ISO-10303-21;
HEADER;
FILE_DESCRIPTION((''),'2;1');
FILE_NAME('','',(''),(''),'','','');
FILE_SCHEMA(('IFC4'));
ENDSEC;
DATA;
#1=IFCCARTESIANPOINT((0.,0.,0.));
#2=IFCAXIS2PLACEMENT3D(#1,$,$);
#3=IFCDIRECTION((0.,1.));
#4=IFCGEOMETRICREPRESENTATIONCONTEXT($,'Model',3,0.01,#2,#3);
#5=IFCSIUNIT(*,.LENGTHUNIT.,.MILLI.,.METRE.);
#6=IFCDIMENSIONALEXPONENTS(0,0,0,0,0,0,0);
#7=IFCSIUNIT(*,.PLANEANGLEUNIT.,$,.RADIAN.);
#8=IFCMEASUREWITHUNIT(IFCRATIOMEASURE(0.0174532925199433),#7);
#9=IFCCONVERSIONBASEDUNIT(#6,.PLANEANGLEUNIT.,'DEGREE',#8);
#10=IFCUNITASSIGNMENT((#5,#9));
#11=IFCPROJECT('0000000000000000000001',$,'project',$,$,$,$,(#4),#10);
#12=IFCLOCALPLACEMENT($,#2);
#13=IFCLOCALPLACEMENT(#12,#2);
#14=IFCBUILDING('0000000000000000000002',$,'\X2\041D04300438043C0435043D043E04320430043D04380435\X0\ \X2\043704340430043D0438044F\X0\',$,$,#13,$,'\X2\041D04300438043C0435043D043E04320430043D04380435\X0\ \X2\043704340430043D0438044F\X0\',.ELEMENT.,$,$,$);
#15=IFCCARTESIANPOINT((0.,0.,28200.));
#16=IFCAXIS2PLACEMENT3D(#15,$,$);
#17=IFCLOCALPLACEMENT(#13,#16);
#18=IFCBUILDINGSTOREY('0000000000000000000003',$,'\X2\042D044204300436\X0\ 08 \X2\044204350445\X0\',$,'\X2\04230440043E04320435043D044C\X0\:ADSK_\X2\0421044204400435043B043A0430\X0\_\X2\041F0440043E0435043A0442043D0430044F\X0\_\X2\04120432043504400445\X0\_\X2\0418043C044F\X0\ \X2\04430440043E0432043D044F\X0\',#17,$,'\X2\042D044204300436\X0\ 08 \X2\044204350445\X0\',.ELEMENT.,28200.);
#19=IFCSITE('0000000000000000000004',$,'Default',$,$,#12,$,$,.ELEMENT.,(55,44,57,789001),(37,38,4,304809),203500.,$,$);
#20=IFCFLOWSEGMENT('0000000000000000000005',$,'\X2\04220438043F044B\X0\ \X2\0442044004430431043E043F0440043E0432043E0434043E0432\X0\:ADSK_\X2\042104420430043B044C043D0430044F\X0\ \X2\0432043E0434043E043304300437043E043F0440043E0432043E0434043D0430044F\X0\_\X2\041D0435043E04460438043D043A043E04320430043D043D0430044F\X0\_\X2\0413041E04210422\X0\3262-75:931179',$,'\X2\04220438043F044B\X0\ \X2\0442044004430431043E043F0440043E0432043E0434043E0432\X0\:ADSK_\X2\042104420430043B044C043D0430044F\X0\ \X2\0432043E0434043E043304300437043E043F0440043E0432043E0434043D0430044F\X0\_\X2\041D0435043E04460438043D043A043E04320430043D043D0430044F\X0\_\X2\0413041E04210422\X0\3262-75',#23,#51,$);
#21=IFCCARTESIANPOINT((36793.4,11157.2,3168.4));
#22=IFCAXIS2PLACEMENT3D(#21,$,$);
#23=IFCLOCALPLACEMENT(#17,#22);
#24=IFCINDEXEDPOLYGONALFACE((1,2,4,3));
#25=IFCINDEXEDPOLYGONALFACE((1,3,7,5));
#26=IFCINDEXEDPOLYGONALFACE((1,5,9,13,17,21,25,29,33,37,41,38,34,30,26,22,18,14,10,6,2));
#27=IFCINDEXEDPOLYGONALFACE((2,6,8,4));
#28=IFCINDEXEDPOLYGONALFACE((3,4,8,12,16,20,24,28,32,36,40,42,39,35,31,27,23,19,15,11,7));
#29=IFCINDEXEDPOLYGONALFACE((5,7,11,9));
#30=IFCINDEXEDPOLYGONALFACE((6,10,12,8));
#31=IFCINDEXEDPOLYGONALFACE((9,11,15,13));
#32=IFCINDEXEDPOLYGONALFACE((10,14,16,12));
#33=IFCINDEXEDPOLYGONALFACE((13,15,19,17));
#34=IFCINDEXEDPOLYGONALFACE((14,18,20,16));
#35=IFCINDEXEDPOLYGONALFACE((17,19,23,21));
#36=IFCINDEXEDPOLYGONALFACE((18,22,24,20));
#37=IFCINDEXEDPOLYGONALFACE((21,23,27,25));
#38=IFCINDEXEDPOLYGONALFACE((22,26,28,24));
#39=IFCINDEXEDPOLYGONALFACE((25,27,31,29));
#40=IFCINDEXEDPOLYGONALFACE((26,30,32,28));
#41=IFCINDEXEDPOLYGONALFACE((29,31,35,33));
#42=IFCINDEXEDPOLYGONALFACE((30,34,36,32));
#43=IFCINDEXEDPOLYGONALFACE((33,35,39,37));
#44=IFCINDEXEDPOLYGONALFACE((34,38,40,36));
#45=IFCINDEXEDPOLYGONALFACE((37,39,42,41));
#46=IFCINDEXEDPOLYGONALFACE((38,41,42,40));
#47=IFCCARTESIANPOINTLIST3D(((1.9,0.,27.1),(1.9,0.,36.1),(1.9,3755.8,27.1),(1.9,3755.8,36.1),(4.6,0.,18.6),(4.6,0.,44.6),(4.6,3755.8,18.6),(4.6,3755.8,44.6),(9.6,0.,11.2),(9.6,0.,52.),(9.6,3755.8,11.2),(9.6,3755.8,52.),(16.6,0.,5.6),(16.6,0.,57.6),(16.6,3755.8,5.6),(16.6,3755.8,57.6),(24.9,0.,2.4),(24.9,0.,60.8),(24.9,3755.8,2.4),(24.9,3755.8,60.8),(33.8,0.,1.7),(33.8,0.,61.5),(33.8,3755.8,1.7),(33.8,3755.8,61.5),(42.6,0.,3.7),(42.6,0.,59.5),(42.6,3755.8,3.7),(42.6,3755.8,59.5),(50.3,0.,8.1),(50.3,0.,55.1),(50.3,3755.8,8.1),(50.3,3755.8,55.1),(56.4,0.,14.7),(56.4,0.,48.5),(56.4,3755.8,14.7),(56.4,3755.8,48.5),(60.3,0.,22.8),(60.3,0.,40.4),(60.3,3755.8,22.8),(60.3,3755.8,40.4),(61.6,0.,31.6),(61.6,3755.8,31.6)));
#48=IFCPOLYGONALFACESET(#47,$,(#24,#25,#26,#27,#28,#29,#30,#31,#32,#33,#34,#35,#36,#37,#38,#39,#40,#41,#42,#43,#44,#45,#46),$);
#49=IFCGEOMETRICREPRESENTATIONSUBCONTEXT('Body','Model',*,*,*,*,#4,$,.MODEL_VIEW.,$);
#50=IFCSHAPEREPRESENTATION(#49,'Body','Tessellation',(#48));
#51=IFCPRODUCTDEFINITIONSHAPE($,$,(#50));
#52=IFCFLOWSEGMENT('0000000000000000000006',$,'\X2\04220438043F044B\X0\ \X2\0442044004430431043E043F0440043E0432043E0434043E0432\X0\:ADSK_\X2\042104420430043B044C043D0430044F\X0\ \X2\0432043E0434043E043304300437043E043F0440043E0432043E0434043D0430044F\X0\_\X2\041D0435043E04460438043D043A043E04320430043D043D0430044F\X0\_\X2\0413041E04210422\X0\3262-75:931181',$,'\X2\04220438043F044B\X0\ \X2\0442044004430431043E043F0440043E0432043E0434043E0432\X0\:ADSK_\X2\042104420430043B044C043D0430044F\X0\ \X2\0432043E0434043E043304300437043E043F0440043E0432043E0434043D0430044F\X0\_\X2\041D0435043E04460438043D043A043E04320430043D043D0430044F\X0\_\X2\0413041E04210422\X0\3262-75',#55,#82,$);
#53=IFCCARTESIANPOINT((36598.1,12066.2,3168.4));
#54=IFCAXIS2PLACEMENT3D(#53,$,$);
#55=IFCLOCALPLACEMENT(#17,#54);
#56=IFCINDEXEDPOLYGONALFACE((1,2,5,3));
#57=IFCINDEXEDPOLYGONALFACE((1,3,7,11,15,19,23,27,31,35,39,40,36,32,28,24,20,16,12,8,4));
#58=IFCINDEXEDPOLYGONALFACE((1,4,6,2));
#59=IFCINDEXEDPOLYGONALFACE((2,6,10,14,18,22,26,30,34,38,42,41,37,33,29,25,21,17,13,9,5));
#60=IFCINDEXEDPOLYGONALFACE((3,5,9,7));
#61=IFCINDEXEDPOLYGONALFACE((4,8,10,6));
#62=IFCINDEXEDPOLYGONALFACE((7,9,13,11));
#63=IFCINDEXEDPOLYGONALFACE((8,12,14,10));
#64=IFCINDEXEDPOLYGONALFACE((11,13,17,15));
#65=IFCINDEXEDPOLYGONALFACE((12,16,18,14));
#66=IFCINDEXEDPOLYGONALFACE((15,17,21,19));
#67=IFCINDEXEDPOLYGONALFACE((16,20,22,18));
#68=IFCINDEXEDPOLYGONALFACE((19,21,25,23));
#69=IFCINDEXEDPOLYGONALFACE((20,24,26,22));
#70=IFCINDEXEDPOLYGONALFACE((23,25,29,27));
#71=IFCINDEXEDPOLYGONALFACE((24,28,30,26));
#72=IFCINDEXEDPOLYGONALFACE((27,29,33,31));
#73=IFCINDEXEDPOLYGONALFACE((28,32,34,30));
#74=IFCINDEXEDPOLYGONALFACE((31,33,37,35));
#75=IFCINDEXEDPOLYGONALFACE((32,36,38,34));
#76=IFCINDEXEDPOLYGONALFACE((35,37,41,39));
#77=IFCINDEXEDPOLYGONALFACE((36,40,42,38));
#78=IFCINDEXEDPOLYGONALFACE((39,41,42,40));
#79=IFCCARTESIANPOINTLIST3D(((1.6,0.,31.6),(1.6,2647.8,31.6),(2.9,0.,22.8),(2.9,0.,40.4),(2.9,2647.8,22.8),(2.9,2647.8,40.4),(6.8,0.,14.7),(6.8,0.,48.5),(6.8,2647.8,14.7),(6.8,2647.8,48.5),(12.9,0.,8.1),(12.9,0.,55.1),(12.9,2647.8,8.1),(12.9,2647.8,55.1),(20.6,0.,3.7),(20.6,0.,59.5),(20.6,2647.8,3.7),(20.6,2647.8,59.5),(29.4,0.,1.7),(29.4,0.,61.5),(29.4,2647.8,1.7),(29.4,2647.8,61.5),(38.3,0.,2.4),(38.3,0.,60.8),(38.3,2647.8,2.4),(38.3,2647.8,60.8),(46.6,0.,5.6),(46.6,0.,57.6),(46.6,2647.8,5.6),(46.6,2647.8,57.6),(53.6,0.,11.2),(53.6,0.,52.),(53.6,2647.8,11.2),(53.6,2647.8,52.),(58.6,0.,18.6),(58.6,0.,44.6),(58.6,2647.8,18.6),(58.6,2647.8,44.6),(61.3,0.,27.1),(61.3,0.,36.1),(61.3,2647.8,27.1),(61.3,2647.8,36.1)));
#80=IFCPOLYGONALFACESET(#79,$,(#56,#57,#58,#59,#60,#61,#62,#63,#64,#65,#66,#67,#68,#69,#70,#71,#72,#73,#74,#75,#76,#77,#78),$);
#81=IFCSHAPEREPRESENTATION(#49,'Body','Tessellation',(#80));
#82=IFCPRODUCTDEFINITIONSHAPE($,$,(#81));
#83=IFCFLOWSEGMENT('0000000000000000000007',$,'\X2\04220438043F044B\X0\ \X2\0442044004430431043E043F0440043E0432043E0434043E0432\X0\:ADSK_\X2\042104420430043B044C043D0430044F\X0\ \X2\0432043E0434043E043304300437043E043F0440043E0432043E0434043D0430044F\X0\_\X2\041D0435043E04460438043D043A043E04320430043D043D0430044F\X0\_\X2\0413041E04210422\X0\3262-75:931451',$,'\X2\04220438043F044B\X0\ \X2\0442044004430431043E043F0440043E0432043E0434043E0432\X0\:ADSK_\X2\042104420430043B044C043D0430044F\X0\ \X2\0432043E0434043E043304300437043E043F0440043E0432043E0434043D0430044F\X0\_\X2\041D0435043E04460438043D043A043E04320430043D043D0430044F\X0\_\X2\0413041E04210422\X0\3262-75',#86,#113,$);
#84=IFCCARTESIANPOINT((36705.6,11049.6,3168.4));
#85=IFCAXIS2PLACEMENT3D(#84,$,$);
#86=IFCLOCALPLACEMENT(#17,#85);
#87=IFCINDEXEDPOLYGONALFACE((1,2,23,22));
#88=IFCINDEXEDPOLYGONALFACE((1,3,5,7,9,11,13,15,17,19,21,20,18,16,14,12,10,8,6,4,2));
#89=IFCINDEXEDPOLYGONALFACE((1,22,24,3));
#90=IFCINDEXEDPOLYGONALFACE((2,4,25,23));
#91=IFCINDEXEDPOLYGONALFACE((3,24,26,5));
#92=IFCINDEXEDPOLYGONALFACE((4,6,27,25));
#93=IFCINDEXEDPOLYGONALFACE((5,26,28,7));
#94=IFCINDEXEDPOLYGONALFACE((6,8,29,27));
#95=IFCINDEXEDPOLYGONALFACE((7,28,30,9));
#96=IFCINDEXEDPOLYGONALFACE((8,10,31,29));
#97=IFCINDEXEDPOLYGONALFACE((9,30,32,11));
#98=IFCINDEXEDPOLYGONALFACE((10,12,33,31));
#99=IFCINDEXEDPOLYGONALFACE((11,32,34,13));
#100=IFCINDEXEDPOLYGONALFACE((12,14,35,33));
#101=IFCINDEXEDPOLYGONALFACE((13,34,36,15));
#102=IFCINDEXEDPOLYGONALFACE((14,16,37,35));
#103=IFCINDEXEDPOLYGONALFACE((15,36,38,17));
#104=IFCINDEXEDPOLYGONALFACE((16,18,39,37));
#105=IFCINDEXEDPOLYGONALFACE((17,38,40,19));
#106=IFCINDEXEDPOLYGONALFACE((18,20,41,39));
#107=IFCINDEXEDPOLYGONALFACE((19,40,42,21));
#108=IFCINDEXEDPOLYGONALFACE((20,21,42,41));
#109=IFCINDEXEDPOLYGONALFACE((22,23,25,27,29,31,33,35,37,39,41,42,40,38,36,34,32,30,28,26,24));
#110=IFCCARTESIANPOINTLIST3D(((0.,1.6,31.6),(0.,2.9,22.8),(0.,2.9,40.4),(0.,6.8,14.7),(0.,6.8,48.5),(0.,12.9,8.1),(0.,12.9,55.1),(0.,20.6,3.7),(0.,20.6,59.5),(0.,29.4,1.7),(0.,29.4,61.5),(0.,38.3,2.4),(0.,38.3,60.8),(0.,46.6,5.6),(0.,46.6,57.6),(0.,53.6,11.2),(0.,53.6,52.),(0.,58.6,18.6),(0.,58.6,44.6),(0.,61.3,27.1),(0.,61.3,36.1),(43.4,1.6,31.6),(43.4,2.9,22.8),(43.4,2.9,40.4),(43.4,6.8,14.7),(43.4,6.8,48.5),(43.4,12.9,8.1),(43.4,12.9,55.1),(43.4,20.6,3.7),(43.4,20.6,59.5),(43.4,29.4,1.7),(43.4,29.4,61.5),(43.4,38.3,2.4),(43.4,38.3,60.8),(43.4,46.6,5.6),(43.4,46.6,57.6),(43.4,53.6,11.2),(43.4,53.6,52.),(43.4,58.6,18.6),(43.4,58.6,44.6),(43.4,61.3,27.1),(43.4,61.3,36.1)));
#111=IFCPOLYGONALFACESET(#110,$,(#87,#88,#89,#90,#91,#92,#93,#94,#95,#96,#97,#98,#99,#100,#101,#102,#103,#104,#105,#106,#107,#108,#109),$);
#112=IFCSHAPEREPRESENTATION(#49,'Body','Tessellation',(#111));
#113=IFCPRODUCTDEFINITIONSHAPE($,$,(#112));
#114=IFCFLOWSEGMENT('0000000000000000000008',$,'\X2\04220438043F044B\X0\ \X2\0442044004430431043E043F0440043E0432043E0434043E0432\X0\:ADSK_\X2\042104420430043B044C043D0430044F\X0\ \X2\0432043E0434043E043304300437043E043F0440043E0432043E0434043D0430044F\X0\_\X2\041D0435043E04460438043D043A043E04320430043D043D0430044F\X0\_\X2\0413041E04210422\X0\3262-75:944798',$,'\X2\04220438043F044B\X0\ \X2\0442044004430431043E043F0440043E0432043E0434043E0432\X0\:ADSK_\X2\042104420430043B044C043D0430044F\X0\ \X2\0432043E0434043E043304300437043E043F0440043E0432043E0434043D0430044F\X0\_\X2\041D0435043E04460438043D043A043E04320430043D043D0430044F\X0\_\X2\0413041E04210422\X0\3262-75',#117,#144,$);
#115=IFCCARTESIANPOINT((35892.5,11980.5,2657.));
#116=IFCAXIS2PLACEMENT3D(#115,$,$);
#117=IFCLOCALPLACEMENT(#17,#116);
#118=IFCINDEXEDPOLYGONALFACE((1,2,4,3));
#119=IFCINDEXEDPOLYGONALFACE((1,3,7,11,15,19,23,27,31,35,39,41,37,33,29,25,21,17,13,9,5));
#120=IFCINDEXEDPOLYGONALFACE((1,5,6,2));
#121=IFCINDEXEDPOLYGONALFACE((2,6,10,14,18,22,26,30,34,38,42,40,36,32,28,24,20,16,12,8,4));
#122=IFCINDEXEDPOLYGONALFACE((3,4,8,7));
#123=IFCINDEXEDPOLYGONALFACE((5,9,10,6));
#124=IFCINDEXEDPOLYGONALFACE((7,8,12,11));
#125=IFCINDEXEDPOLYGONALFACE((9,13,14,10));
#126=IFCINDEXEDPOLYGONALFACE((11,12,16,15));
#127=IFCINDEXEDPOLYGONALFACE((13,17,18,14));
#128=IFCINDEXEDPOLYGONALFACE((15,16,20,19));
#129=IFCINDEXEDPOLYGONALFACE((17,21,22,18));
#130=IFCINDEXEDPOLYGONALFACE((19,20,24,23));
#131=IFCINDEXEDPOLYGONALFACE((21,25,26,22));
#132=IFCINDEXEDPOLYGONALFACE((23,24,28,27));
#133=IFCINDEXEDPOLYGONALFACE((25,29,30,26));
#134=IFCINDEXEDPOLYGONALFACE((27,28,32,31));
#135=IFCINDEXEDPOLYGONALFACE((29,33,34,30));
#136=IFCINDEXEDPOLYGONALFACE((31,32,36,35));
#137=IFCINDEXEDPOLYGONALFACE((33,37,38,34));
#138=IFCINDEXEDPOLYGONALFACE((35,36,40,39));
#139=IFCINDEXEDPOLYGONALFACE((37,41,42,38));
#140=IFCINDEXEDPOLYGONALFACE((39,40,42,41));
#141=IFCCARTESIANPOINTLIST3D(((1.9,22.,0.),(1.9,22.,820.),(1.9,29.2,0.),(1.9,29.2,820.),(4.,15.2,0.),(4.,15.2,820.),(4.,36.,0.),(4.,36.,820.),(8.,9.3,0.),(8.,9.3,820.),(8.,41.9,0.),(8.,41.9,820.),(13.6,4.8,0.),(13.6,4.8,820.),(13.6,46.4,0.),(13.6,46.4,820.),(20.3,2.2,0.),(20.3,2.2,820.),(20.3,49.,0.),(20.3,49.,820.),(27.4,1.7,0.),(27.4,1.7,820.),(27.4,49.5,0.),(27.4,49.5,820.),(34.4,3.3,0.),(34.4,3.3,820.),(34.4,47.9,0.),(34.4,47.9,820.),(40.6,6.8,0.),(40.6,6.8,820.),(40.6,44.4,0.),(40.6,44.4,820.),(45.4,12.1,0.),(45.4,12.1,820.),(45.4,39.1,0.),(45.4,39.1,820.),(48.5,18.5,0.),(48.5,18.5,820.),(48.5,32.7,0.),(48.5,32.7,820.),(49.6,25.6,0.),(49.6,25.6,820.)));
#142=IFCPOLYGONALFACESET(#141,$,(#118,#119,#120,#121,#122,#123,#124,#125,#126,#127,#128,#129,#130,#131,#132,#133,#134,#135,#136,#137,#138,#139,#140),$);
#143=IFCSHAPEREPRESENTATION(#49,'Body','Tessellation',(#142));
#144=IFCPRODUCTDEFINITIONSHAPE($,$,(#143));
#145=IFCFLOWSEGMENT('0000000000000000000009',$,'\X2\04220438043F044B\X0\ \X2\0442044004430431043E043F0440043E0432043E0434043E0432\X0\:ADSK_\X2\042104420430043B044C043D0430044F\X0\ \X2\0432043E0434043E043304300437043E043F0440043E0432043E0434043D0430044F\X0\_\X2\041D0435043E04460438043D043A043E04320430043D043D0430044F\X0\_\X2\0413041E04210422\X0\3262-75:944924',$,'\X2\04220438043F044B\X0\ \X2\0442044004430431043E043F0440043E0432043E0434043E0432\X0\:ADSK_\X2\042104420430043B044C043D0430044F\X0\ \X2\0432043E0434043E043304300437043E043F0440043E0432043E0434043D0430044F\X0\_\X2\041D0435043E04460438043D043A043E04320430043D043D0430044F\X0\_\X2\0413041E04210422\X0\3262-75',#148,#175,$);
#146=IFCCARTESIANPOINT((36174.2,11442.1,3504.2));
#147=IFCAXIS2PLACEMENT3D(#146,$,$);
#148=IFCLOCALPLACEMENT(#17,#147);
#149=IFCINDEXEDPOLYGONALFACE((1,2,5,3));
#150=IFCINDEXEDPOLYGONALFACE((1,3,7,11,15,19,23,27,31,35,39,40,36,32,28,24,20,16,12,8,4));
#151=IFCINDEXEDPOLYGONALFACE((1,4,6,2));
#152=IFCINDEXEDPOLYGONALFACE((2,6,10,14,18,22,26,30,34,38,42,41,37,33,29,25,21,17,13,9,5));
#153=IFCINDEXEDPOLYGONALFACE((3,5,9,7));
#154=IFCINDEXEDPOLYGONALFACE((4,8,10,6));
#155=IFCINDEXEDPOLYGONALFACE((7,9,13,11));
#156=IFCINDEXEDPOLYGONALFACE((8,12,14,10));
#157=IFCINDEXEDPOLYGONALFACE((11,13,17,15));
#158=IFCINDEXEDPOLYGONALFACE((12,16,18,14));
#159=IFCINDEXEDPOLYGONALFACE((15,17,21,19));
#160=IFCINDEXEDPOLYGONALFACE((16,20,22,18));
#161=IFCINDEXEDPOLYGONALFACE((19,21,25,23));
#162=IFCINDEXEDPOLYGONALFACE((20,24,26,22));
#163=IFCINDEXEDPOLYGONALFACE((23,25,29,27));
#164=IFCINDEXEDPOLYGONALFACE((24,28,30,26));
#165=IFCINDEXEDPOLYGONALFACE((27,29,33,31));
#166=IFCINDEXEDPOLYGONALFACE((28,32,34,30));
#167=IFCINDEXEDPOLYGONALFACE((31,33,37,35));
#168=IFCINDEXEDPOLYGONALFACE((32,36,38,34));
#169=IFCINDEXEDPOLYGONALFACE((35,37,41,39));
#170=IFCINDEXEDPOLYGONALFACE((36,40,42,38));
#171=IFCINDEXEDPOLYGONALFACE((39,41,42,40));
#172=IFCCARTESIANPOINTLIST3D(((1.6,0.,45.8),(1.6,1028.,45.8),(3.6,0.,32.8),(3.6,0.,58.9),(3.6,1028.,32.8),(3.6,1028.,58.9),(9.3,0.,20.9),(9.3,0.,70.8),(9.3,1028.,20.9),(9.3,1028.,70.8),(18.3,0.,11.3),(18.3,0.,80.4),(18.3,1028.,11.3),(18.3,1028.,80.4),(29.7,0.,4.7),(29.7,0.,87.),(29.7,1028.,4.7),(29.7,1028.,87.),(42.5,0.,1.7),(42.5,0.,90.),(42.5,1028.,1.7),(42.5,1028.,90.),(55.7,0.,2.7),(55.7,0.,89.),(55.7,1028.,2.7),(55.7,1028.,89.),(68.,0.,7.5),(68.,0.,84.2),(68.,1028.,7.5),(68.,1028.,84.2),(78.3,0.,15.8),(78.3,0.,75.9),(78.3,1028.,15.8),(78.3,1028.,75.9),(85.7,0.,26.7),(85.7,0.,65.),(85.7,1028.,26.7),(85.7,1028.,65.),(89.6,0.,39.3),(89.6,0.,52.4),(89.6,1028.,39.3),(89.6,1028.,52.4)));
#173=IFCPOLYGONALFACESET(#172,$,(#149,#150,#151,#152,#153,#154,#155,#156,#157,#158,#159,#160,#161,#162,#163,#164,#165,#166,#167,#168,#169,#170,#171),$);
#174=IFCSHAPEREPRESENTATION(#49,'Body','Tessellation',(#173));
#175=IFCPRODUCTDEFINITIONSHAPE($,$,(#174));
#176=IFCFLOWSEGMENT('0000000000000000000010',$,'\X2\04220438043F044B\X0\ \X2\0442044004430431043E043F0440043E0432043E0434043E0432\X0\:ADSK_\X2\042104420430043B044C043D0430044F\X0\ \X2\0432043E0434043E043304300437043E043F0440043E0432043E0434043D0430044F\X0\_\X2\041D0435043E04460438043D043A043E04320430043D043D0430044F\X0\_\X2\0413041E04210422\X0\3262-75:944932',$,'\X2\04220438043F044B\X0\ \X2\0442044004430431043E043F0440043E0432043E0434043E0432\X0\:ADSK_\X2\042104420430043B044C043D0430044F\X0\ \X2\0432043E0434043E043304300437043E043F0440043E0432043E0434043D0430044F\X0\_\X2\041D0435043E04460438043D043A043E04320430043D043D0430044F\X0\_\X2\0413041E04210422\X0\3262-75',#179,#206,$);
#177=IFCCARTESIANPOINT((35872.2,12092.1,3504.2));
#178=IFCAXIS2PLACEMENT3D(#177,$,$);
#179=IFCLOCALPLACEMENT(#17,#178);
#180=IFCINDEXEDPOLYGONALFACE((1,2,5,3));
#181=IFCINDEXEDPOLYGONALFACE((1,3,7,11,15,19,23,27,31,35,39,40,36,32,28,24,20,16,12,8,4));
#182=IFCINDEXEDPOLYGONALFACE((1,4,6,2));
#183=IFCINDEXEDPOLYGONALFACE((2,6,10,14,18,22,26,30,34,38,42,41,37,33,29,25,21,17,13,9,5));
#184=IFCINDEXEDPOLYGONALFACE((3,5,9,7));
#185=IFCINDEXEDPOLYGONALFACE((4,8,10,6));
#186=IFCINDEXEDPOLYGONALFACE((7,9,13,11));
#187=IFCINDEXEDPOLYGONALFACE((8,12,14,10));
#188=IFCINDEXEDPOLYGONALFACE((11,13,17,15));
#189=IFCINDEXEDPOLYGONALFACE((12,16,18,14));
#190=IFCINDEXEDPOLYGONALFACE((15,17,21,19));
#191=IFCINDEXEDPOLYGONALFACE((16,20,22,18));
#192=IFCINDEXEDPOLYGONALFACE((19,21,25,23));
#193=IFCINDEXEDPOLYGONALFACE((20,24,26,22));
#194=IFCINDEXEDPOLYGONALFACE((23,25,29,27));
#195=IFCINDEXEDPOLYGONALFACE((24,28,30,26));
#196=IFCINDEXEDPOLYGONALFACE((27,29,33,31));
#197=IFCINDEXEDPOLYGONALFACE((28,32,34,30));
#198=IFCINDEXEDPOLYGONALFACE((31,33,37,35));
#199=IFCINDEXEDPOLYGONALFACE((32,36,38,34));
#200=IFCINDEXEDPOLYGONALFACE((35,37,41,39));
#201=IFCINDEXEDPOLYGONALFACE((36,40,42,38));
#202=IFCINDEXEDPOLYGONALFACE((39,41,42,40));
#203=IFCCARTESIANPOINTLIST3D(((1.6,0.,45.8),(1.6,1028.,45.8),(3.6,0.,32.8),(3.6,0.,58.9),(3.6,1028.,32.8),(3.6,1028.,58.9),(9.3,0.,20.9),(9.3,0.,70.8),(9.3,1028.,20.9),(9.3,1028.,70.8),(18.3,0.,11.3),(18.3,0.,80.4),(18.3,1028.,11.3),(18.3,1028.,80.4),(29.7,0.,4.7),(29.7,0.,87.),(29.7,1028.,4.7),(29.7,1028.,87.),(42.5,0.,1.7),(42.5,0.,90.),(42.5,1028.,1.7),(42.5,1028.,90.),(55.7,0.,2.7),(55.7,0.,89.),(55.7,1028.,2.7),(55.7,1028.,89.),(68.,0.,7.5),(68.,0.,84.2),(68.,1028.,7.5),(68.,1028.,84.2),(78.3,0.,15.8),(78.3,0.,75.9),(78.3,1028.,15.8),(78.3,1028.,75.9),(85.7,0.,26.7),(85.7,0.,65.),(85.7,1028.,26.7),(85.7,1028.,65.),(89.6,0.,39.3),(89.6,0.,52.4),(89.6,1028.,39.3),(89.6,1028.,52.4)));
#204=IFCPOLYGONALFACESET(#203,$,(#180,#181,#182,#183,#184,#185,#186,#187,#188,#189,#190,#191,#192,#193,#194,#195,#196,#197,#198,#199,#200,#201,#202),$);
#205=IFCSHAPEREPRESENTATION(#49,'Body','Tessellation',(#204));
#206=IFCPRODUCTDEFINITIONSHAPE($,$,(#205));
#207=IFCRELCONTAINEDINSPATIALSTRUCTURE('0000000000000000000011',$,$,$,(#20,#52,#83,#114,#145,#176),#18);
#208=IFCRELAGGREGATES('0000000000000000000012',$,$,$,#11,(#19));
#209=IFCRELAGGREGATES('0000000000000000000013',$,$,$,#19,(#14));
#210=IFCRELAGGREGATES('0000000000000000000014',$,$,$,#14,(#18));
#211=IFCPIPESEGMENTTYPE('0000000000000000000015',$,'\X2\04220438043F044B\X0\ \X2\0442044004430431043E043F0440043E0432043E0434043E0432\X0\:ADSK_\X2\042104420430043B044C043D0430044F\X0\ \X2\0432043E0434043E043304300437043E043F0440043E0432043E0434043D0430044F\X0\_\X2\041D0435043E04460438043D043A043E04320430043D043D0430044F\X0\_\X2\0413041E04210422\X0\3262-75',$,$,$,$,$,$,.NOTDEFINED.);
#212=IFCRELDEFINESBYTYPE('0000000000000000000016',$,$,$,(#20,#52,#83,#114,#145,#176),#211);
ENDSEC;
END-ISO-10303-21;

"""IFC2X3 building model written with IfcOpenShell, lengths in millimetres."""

from ifc_helpers import new_model, entity, si_unit, converted_unit, direction, frame, origin, origin_2d_with_axis, place, context, subcontext, project, spatial, circle, extrude, type_object, element, save


model = new_model("IFC2X3")

# Units and contexts
model_context = context("Model", 3, precision=0.01, world=origin(), true_north=direction((0.0, 1.0)))
body_context = subcontext(model_context, "Body", "Model", "MODEL_VIEW")
ifc_project = project(units=[si_unit("LENGTHUNIT", "METRE", prefix="MILLI"), converted_unit("PLANEANGLEUNIT", "DEGREE", entity("IfcRatioMeasure", 0.0174532925199433), si_unit("PLANEANGLEUNIT", "RADIAN"), dimensions=[0, 0, 0, 0, 0, 0, 0])], contexts=[model_context])

# Site, building, storey
site_placement = place(None, origin())
site = spatial("IfcSite", under=ifc_project, at=site_placement, Name="Default", CompositionType="ELEMENT", RefLatitude=(55, 44, 57, 789001), RefLongitude=(37, 38, 4, 304809), RefElevation=203500.0)
building_placement = place(site_placement, origin())
building = spatial("IfcBuilding", under=site, at=building_placement, Name="Наименование здания", LongName="Наименование здания", CompositionType="ELEMENT")
storey_placement = place(building_placement, frame((0.0, 0.0, 28200.0)))
storey = spatial("IfcBuildingStorey", under=building, at=storey_placement, Name="Этаж 08 тех", ObjectType="Уровень:ADSK_Стрелка_Проектная_Вверх_Имя уровня", LongName="Этаж 08 тех", CompositionType="ELEMENT", Elevation=28200.0)

# Flow segments
pipe_segment_type = type_object("IfcPipeSegmentType", Name="Типы трубопроводов:ADSK_Стальная водогазопроводная_Неоцинкованная_ГОСТ3262-75", PredefinedType="NOTDEFINED")
flow_segment_1_placement = place(storey_placement, frame((36793.4, 11157.2, 3168.4)))
element("IfcFlowSegment", 1, at=flow_segment_1_placement, inside=storey, type_object=pipe_segment_type, Name="Типы трубопроводов:ADSK_Стальная водогазопроводная_Неоцинкованная_ГОСТ3262-75:931179", ObjectType="Типы трубопроводов:ADSK_Стальная водогазопроводная_Неоцинкованная_ГОСТ3262-75", context=body_context, shape_type="SweptSolid", body=[
    extrude(circle(Radius=30.0, at=origin_2d_with_axis()), frame((31.6, 0.0, 31.6), z_axis=(0.0, 1.0, 0.0), x_axis=(1.0, 0.0, 0.0)), (0.0, 0.0, 1.0), 3755.8),
])
flow_segment_2_placement = place(storey_placement, frame((36598.1, 12066.2, 3168.4)))
element("IfcFlowSegment", 2, at=flow_segment_2_placement, inside=storey, type_object=pipe_segment_type, Name="Типы трубопроводов:ADSK_Стальная водогазопроводная_Неоцинкованная_ГОСТ3262-75:931181", ObjectType="Типы трубопроводов:ADSK_Стальная водогазопроводная_Неоцинкованная_ГОСТ3262-75", context=body_context, shape_type="SweptSolid", body=[
    extrude(circle(Radius=30.0, at=origin_2d_with_axis()), frame((31.6, 0.0, 31.6), z_axis=(0.0, 1.0, 0.0), x_axis=(-1.0, 0.0, 0.0)), (0.0, 0.0, 1.0), 2647.8),
])
flow_segment_3_placement = place(storey_placement, frame((36705.6, 11049.6, 3168.4)))
element("IfcFlowSegment", 3, at=flow_segment_3_placement, inside=storey, type_object=pipe_segment_type, Name="Типы трубопроводов:ADSK_Стальная водогазопроводная_Неоцинкованная_ГОСТ3262-75:931451", ObjectType="Типы трубопроводов:ADSK_Стальная водогазопроводная_Неоцинкованная_ГОСТ3262-75", context=body_context, shape_type="SweptSolid", body=[
    extrude(circle(Radius=30.0, at=origin_2d_with_axis()), frame((0.0, 31.6, 31.6), z_axis=(1.0, 0.0, 0.0), x_axis=(0.0, -1.0, 0.0)), (0.0, 0.0, 1.0), 43.4),
])
flow_segment_4_placement = place(storey_placement, frame((35892.5, 11980.5, 2657.0)))
element("IfcFlowSegment", 4, at=flow_segment_4_placement, inside=storey, type_object=pipe_segment_type, Name="Типы трубопроводов:ADSK_Стальная водогазопроводная_Неоцинкованная_ГОСТ3262-75:944798", ObjectType="Типы трубопроводов:ADSK_Стальная водогазопроводная_Неоцинкованная_ГОСТ3262-75", context=body_context, shape_type="SweptSolid", body=[
    extrude(circle(Radius=24.0, at=origin_2d_with_axis()), frame((25.6, 25.6, 0.0)), (0.0, 0.0, 1.0), 820.0),
])
for number, where, name in (
    (5, (36174.2, 11442.1, 3504.2), "Типы трубопроводов:ADSK_Стальная водогазопроводная_Неоцинкованная_ГОСТ3262-75:944924"),
    (6, (35872.2, 12092.1, 3504.2), "Типы трубопроводов:ADSK_Стальная водогазопроводная_Неоцинкованная_ГОСТ3262-75:944932"),
):
    element("IfcFlowSegment", number, at=place(storey_placement, frame(where)), inside=storey, type_object=pipe_segment_type, Name=name, ObjectType="Типы трубопроводов:ADSK_Стальная водогазопроводная_Неоцинкованная_ГОСТ3262-75", context=body_context, shape_type="SweptSolid", body=[
        extrude(circle(Radius=44.2, at=origin_2d_with_axis()), frame((45.9, 0.0, 45.9), z_axis=(0.0, 1.0, 0.0), x_axis=(-1.0, 0.0, 0.0)), (0.0, 0.0, 1.0), 1028.0),
    ])

save(model, "model.ifc")
